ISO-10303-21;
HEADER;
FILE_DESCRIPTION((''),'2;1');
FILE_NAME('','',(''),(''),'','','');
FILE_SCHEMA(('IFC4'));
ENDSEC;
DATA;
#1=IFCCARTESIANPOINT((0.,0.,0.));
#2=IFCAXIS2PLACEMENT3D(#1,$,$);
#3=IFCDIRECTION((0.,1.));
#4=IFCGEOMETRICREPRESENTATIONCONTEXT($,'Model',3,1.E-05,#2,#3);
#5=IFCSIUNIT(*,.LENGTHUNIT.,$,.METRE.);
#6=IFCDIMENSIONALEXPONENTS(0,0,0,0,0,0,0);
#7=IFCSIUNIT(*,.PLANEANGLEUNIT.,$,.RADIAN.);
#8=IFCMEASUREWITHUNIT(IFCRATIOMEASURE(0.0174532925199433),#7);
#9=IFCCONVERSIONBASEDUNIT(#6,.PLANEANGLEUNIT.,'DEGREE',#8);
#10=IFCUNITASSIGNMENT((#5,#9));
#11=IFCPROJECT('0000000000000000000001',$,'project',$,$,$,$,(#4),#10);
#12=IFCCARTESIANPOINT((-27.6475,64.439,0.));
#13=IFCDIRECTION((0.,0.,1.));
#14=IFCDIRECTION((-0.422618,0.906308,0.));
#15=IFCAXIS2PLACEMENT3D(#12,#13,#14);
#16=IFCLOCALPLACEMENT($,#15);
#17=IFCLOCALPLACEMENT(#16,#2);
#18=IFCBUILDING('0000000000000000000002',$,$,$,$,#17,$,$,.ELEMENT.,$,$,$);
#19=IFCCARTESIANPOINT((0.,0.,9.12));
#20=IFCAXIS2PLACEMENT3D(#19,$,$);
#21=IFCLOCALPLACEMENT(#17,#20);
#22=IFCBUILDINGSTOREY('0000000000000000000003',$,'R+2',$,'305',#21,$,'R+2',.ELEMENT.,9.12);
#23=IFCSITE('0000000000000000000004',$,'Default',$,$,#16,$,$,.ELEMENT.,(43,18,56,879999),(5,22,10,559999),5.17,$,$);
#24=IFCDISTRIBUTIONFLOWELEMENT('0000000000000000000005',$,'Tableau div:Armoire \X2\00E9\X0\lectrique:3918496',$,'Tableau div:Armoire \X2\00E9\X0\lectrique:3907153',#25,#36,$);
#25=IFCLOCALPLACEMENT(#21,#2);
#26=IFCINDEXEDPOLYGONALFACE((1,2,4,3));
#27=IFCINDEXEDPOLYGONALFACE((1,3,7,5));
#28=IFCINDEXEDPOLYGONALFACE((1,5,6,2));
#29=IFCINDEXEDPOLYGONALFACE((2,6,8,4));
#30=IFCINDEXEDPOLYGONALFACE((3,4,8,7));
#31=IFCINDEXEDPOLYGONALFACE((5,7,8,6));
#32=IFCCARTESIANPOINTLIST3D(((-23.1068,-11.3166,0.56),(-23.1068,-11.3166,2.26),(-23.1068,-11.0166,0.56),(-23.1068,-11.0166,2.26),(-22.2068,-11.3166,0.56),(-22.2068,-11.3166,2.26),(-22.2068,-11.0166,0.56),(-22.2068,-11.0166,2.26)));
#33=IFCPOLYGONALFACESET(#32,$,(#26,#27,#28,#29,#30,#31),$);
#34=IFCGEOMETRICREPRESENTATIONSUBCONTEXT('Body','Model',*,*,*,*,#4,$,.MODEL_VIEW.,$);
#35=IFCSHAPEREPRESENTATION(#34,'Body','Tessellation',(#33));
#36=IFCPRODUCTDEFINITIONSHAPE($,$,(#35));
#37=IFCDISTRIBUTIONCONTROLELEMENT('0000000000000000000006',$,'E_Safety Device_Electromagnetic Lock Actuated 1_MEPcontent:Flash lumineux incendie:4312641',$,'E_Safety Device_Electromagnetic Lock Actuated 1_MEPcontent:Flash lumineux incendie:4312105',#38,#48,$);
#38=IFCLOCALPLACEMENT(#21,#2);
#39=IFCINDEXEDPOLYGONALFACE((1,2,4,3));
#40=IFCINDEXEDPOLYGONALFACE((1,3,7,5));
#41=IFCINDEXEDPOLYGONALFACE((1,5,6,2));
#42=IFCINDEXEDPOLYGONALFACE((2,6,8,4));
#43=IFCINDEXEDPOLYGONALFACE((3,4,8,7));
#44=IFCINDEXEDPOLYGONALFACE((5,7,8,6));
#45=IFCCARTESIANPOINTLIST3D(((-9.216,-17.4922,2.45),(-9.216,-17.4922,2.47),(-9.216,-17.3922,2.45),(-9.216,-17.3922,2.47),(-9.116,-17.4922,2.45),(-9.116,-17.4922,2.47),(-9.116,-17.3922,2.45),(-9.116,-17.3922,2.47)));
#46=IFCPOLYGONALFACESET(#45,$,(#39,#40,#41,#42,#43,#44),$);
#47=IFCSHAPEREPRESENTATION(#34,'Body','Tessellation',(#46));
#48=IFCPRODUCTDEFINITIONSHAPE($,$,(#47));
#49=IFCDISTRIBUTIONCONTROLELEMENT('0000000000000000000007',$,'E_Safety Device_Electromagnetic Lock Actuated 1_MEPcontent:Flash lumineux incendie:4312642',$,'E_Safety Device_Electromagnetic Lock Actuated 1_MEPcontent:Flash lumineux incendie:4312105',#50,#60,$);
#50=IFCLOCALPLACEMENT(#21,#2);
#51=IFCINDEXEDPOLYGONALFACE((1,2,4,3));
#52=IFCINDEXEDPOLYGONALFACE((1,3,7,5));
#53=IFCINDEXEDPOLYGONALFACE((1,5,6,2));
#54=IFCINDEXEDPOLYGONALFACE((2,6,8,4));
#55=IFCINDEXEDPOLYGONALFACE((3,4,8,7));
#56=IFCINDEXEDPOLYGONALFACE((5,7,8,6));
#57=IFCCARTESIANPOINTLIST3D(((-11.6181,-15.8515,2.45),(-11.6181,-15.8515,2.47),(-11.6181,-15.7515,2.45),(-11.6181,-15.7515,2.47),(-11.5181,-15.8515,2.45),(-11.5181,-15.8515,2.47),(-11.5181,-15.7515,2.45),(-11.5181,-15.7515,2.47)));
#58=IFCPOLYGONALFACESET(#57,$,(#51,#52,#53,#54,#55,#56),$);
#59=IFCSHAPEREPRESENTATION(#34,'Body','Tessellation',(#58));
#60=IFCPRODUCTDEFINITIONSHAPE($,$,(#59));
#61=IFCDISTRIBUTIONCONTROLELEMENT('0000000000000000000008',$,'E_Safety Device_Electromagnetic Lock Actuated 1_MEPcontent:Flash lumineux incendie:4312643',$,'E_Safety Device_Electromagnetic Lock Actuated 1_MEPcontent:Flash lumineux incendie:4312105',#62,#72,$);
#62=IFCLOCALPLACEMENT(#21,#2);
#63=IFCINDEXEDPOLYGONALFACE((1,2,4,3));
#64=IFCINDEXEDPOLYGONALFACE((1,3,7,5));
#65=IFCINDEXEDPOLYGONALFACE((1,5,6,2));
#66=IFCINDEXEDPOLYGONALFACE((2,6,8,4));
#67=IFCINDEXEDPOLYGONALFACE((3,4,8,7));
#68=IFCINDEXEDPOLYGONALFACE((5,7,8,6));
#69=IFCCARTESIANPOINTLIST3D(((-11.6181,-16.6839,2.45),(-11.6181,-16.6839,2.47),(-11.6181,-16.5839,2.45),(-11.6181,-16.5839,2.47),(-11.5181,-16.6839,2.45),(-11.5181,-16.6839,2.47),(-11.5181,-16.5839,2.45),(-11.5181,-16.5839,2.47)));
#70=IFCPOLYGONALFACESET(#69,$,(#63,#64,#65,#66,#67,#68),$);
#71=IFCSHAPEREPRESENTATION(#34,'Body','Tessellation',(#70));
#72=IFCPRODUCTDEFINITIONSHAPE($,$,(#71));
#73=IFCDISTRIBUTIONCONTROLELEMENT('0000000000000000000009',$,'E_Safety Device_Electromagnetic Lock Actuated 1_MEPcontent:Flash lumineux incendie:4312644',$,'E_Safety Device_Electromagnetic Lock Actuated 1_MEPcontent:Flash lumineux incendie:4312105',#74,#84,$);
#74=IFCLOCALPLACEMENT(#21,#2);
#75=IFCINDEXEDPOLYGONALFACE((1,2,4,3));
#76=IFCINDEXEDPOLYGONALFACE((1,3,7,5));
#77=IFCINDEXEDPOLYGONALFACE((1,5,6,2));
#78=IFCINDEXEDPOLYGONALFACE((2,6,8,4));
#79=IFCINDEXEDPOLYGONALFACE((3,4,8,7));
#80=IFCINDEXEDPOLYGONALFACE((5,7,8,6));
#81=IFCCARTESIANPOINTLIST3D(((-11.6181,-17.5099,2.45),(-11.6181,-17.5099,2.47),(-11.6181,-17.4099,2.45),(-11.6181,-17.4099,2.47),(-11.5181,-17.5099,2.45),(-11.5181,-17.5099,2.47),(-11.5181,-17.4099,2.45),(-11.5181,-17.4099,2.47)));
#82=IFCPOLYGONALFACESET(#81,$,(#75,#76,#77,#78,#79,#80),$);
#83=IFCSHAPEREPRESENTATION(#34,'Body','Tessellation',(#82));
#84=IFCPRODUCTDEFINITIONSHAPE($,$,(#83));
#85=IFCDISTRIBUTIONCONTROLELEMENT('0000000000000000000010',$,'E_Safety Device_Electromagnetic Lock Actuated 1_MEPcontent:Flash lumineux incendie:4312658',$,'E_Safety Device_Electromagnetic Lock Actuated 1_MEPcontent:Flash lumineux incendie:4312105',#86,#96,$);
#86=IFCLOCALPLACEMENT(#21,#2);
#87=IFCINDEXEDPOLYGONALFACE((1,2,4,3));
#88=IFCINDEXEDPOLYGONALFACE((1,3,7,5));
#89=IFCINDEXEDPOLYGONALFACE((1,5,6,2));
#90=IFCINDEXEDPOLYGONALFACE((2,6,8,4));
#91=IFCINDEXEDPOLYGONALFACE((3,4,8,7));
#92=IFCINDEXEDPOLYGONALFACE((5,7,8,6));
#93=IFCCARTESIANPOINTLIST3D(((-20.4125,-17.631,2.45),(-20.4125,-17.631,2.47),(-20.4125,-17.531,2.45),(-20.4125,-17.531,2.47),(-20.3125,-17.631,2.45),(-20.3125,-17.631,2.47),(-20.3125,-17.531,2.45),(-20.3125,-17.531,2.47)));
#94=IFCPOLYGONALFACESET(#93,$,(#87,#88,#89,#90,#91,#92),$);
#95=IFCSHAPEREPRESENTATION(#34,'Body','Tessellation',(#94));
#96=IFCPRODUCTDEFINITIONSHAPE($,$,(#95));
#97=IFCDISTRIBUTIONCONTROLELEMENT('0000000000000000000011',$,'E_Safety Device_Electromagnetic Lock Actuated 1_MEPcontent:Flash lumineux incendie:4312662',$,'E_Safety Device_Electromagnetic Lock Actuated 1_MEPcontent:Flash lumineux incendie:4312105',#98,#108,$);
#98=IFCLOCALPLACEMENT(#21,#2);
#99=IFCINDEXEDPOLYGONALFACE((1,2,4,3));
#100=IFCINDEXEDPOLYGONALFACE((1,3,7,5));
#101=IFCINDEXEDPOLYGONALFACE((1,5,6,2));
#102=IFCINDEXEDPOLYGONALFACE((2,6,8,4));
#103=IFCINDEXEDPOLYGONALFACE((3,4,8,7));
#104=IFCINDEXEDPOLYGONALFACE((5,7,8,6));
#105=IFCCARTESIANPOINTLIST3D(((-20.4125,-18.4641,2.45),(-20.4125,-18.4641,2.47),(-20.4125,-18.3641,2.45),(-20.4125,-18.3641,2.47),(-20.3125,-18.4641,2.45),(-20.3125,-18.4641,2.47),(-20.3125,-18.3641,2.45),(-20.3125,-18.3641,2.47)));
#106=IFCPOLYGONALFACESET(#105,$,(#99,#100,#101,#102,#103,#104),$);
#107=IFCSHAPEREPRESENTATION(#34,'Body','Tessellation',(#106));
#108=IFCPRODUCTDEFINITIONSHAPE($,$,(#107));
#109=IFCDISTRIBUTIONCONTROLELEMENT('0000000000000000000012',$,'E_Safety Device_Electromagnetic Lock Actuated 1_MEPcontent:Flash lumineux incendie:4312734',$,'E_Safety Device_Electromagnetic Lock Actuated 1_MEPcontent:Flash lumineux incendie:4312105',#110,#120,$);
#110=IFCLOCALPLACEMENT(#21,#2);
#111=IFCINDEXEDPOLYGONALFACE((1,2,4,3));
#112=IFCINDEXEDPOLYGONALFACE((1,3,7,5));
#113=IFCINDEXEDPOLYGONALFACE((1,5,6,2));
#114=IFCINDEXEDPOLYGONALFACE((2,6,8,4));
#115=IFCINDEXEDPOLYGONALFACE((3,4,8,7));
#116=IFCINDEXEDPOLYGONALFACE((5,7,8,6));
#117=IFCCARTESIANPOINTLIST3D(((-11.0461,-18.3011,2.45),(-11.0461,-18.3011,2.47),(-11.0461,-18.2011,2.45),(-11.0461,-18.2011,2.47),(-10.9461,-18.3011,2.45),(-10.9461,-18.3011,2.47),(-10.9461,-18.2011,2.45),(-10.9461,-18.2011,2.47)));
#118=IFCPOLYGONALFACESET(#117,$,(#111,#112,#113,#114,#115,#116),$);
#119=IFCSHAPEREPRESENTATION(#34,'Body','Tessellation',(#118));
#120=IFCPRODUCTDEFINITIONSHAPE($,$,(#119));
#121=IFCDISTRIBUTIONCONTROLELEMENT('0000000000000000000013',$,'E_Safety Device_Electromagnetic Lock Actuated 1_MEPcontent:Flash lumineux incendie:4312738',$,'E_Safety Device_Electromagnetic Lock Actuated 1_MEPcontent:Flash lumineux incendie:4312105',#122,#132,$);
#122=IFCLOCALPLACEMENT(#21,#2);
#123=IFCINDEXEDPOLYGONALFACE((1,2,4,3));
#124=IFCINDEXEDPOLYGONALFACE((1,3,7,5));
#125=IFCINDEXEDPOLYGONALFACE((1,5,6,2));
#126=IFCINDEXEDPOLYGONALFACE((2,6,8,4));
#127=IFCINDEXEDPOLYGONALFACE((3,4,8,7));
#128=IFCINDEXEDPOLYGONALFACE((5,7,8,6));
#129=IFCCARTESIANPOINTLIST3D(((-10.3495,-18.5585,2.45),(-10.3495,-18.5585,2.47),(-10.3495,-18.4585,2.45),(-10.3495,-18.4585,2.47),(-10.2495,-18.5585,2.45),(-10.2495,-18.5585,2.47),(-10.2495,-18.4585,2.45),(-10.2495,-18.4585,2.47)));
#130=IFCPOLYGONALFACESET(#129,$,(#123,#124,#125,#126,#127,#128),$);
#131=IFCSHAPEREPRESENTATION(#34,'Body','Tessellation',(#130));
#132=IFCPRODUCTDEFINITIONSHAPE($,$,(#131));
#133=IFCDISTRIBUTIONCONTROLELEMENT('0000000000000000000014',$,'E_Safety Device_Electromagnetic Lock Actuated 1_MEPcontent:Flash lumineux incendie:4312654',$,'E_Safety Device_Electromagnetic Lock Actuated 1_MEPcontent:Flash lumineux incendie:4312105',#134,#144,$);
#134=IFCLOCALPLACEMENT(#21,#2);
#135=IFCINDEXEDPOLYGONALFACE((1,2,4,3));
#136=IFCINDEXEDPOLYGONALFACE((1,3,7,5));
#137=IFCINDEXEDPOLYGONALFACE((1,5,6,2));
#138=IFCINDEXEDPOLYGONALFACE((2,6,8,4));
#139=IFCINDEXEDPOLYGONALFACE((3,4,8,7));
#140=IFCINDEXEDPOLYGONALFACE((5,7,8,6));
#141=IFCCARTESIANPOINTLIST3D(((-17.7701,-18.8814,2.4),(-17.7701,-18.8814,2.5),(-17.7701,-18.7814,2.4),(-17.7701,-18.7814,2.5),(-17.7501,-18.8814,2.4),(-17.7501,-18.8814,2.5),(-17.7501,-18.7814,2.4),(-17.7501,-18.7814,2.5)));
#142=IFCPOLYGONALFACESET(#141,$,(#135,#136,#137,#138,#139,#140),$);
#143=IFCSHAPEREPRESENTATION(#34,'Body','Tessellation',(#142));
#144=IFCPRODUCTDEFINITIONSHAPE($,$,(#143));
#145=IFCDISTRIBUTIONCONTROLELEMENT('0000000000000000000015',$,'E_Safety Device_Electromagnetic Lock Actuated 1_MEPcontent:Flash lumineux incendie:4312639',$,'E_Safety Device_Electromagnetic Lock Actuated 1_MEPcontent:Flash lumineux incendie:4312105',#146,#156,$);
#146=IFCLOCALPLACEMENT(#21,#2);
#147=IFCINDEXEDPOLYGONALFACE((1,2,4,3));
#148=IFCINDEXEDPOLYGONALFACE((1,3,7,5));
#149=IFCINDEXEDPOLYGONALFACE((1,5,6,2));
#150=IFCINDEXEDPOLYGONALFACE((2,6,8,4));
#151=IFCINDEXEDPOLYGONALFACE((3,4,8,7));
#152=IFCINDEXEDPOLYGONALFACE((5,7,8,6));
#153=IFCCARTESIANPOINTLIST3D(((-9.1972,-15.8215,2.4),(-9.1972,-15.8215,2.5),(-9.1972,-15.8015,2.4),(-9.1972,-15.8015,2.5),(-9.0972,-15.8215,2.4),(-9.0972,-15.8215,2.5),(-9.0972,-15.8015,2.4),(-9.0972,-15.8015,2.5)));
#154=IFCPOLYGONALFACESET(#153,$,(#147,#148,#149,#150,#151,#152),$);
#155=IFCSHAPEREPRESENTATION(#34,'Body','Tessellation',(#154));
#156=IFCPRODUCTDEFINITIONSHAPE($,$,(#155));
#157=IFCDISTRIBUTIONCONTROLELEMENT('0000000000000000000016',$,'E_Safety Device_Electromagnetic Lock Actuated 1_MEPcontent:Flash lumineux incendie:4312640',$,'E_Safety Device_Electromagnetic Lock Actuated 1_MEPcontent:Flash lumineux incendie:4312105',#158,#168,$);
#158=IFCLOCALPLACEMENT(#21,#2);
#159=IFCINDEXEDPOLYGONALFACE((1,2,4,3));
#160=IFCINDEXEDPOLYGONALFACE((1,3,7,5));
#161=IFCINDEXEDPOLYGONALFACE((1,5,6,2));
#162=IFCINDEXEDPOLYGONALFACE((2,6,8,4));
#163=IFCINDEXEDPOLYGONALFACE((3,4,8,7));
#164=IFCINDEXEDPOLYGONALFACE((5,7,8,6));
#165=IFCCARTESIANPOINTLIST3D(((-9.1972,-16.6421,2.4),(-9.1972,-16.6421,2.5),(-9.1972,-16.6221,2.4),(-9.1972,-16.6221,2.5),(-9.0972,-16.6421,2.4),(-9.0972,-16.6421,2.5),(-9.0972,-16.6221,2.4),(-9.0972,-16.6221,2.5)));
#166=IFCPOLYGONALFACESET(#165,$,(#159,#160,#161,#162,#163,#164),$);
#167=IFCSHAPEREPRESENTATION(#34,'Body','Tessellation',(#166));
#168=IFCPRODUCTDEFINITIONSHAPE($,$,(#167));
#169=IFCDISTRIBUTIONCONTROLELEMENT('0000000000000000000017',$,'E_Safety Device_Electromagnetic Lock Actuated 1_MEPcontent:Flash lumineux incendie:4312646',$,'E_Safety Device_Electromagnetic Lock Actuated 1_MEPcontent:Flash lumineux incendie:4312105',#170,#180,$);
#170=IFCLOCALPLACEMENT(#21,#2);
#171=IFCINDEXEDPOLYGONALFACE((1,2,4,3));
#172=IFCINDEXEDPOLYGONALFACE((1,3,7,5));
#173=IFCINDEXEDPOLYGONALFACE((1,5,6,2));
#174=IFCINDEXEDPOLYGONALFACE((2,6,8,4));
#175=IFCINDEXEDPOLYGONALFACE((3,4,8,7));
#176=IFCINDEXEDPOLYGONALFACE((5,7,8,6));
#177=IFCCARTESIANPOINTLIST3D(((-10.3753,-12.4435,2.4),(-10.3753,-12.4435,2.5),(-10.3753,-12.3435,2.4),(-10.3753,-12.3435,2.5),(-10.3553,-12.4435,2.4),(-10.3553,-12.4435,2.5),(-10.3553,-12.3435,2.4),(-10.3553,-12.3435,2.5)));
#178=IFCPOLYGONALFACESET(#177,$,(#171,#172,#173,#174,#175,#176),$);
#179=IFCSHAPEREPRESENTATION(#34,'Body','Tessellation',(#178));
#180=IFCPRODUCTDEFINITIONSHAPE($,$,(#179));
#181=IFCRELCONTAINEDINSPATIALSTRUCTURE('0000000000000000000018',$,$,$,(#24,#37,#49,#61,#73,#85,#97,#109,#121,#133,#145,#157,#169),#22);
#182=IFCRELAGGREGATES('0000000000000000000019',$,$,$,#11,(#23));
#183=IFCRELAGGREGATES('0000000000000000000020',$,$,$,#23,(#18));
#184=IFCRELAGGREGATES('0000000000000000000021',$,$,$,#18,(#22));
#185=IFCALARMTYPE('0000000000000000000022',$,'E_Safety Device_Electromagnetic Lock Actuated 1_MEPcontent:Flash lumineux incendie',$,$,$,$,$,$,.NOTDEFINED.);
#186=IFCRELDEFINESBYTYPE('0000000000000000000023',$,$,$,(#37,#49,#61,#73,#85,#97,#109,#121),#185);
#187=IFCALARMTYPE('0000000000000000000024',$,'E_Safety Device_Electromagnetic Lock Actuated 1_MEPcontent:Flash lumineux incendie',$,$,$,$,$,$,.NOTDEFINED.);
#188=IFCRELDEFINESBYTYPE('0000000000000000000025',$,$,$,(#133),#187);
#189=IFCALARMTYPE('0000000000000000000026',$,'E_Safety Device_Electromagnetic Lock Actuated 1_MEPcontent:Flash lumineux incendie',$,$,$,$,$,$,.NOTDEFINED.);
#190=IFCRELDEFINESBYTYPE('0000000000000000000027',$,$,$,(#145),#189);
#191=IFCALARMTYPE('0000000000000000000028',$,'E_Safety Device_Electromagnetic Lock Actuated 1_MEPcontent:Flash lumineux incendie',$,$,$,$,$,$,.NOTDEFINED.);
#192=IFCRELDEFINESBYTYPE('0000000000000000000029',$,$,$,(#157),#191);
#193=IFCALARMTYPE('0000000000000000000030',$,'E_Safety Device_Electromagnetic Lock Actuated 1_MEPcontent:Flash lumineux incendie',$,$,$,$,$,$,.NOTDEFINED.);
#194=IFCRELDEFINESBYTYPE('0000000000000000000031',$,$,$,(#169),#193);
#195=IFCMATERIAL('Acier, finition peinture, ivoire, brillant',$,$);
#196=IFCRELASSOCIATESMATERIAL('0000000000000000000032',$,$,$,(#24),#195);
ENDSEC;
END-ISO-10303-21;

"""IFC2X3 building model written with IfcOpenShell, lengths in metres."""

from ifc_helpers import new_model, entity, si_unit, converted_unit, direction, frame, frame_2d, origin, origin_2d_with_axis, place, context, subcontext, project, spatial, rectangle, extrude, source, transform, mapped, material, type_object, type_shapes, element, save


model = new_model("IFC2X3")

# Units and contexts
model_context = context("Model", 3, precision=1e-05, world=origin(), true_north=direction((0.0, 1.0)))
body_context = subcontext(model_context, "Body", "Model", "MODEL_VIEW")
ifc_project = project(units=[si_unit("LENGTHUNIT", "METRE"), converted_unit("PLANEANGLEUNIT", "DEGREE", entity("IfcRatioMeasure", 0.0174532925199433), si_unit("PLANEANGLEUNIT", "RADIAN"), dimensions=[0, 0, 0, 0, 0, 0, 0])], contexts=[model_context])

# Site, building, storey
site_placement = place(None, frame((-27.6475, 64.439, 0.0), z_axis=(0.0, 0.0, 1.0), x_axis=(-0.422618, 0.906308, 0.0)))
site = spatial("IfcSite", under=ifc_project, at=site_placement, Name="Default", CompositionType="ELEMENT", RefLatitude=(43, 18, 56, 879999), RefLongitude=(5, 22, 10, 559999), RefElevation=5.17)
building_placement = place(site_placement, origin())
building = spatial("IfcBuilding", under=site, at=building_placement, CompositionType="ELEMENT")
storey_placement = place(building_placement, frame((0.0, 0.0, 9.12)))
storey = spatial("IfcBuildingStorey", under=building, at=storey_placement, Name="R+2", ObjectType="305", LongName="R+2", CompositionType="ELEMENT", Elevation=9.12)

# Distribution flow element
ifc_material_1 = material(Name="Acier, finition peinture, ivoire, brillant")
shared_shape_1 = source(origin(), body_context, "Body", "SweptSolid", [
    extrude(rectangle(XDim=0.9, YDim=0.3, at=origin_2d_with_axis()), frame((0.0, -0.45, 0.0), z_axis=(0.0, 0.0, 1.0), x_axis=(0.0, 1.0, 0.0)), (0.0, 0.0, 1.0), 1.7),
])
distribution_flow_element_placement = place(storey_placement, frame((-22.2068, -11.1666, 0.56), z_axis=(0.0, 0.0, 1.0), x_axis=(0.0, -1.0, 0.0)))
element("IfcDistributionFlowElement", 1, at=distribution_flow_element_placement, inside=storey, material=ifc_material_1, Name="Tableau div:Armoire électrique:3918496", ObjectType="Tableau div:Armoire électrique:3907153", context=body_context, shape_type="MappedRepresentation", body=[
    mapped(shared_shape_1, transform((0.0, 0.0, 0.0), scale=1.0)),
])

# Distribution control elements
alarm_type_1 = type_object("IfcAlarmType", Name="E_Safety Device_Electromagnetic Lock Actuated 1_MEPcontent:Flash lumineux incendie", PredefinedType="NOTDEFINED")
shared_shape_2 = source(origin(), body_context, "Body", "SweptSolid", [
    extrude(rectangle(XDim=0.1, YDim=0.1, at=origin_2d_with_axis()), frame((0.0, 0.0, 0.0), z_axis=(0.0, 0.0, 1.0), x_axis=(0.0, -1.0, 0.0)), (0.0, 0.0, 1.0), 0.02),
])
type_shapes(alarm_type_1, [shared_shape_2])
for number, where, z_axis, x_axis, name in (
    (2, (-9.166, -17.4422, 2.45), (0.0, 0.0, 1.0), (0.0, -1.0, 0.0), "E_Safety Device_Electromagnetic Lock Actuated 1_MEPcontent:Flash lumineux incendie:4312641"),
    (3, (-11.5681, -15.8015, 2.45), (0.0, 0.0, 1.0), (0.0, -1.0, 0.0), "E_Safety Device_Electromagnetic Lock Actuated 1_MEPcontent:Flash lumineux incendie:4312642"),
    (4, (-11.5681, -16.6339, 2.45), (0.0, 0.0, 1.0), (0.0, -1.0, 0.0), "E_Safety Device_Electromagnetic Lock Actuated 1_MEPcontent:Flash lumineux incendie:4312643"),
    (5, (-11.5681, -17.4599, 2.45), (0.0, 0.0, 1.0), (0.0, -1.0, 0.0), "E_Safety Device_Electromagnetic Lock Actuated 1_MEPcontent:Flash lumineux incendie:4312644"),
    (6, (-20.3625, -17.581, 2.45), (0.0, 0.0, 1.0), (0.0, -1.0, 0.0), "E_Safety Device_Electromagnetic Lock Actuated 1_MEPcontent:Flash lumineux incendie:4312658"),
    (7, (-20.3625, -18.4141, 2.45), (0.0, 0.0, 1.0), (0.0, -1.0, 0.0), "E_Safety Device_Electromagnetic Lock Actuated 1_MEPcontent:Flash lumineux incendie:4312662"),
    (8, (-10.9961, -18.2511, 2.45), (0.0, 0.0, 1.0), (0.0, -1.0, 0.0), "E_Safety Device_Electromagnetic Lock Actuated 1_MEPcontent:Flash lumineux incendie:4312734"),
    (9, (-10.2995, -18.5085, 2.45), (0.0, 0.0, 1.0), (0.0, -1.0, 0.0), "E_Safety Device_Electromagnetic Lock Actuated 1_MEPcontent:Flash lumineux incendie:4312738"),
):
    element("IfcDistributionControlElement", number, at=place(storey_placement, frame(where, z_axis=z_axis, x_axis=x_axis)), inside=storey, type_object=alarm_type_1, Name=name, ObjectType="E_Safety Device_Electromagnetic Lock Actuated 1_MEPcontent:Flash lumineux incendie:4312105", context=body_context, shape_type="MappedRepresentation", body=[
        mapped(shared_shape_2, transform((0.0, 0.0, 0.0), scale=1.0)),
    ])
alarm_type_2 = type_object("IfcAlarmType", Name="E_Safety Device_Electromagnetic Lock Actuated 1_MEPcontent:Flash lumineux incendie", PredefinedType="NOTDEFINED")
shared_shape_3 = source(origin(), body_context, "Body", "SweptSolid", [
    extrude(rectangle(XDim=0.02, YDim=0.1, at=origin_2d_with_axis()), frame((0.0, -0.01, -0.05), z_axis=(0.0, 0.0, 1.0), x_axis=(0.0, 1.0, 0.0)), (0.0, 0.0, 1.0), 0.1),
])
type_shapes(alarm_type_2, [shared_shape_3])
distribution_control_element_1_placement = place(storey_placement, frame((-17.7501, -18.8314, 2.45), z_axis=(0.0, 0.0, 1.0), x_axis=(0.0, -1.0, 0.0)))
element("IfcDistributionControlElement", 10, at=distribution_control_element_1_placement, inside=storey, type_object=alarm_type_2, Name="E_Safety Device_Electromagnetic Lock Actuated 1_MEPcontent:Flash lumineux incendie:4312654", ObjectType="E_Safety Device_Electromagnetic Lock Actuated 1_MEPcontent:Flash lumineux incendie:4312105", context=body_context, shape_type="MappedRepresentation", body=[
    mapped(shared_shape_3, transform((0.0, 0.0, 0.0), scale=1.0)),
])
alarm_type_3 = type_object("IfcAlarmType", Name="E_Safety Device_Electromagnetic Lock Actuated 1_MEPcontent:Flash lumineux incendie", PredefinedType="NOTDEFINED")
shared_shape_4 = source(origin(), body_context, "Body", "SweptSolid", [
    extrude(rectangle(XDim=0.02, YDim=0.1, at=frame_2d((0.0, 0.0), x_axis=(1.0, 0.0))), frame((0.01, 0.0, -0.05), z_axis=(0.0, 0.0, 1.0), x_axis=(-1.0, 0.0, 0.0)), (0.0, 0.0, 1.0), 0.1),
])
type_shapes(alarm_type_3, [shared_shape_4])
distribution_control_element_2_placement = place(storey_placement, frame((-9.1472, -15.8015, 2.45), z_axis=(0.0, 0.0, 1.0), x_axis=(0.0, -1.0, 0.0)))
element("IfcDistributionControlElement", 11, at=distribution_control_element_2_placement, inside=storey, type_object=alarm_type_3, Name="E_Safety Device_Electromagnetic Lock Actuated 1_MEPcontent:Flash lumineux incendie:4312639", ObjectType="E_Safety Device_Electromagnetic Lock Actuated 1_MEPcontent:Flash lumineux incendie:4312105", context=body_context, shape_type="MappedRepresentation", body=[
    mapped(shared_shape_4, transform((0.0, 0.0, 0.0), scale=1.0)),
])
alarm_type_4 = type_object("IfcAlarmType", Name="E_Safety Device_Electromagnetic Lock Actuated 1_MEPcontent:Flash lumineux incendie", PredefinedType="NOTDEFINED")
shared_shape_5 = source(origin(), body_context, "Body", "SweptSolid", [
    extrude(rectangle(XDim=0.02, YDim=0.1, at=frame_2d((0.0, 0.0), x_axis=(1.0, 0.0))), frame((0.01, 0.0, -0.05), z_axis=(0.0, 0.0, 1.0), x_axis=(-1.0, 0.0, 0.0)), (0.0, 0.0, 1.0), 0.1),
])
type_shapes(alarm_type_4, [shared_shape_5])
distribution_control_element_3_placement = place(storey_placement, frame((-9.1472, -16.6221, 2.45), z_axis=(0.0, 0.0, 1.0), x_axis=(0.0, -1.0, 0.0)))
element("IfcDistributionControlElement", 12, at=distribution_control_element_3_placement, inside=storey, type_object=alarm_type_4, Name="E_Safety Device_Electromagnetic Lock Actuated 1_MEPcontent:Flash lumineux incendie:4312640", ObjectType="E_Safety Device_Electromagnetic Lock Actuated 1_MEPcontent:Flash lumineux incendie:4312105", context=body_context, shape_type="MappedRepresentation", body=[
    mapped(shared_shape_5, transform((0.0, 0.0, 0.0), scale=1.0)),
])
alarm_type_5 = type_object("IfcAlarmType", Name="E_Safety Device_Electromagnetic Lock Actuated 1_MEPcontent:Flash lumineux incendie", PredefinedType="NOTDEFINED")
shared_shape_6 = source(origin(), body_context, "Body", "SweptSolid", [
    extrude(rectangle(XDim=0.02, YDim=0.1, at=frame_2d((0.0, 0.0), x_axis=(1.0, 0.0))), frame((0.0, 0.01, -0.05), z_axis=(0.0, 0.0, 1.0), x_axis=(0.0, -1.0, 0.0)), (0.0, 0.0, 1.0), 0.1),
])
type_shapes(alarm_type_5, [shared_shape_6])
distribution_control_element_4_placement = place(storey_placement, frame((-10.3753, -12.3935, 2.45), z_axis=(0.0, 0.0, 1.0), x_axis=(0.0, -1.0, 0.0)))
element("IfcDistributionControlElement", 13, at=distribution_control_element_4_placement, inside=storey, type_object=alarm_type_5, Name="E_Safety Device_Electromagnetic Lock Actuated 1_MEPcontent:Flash lumineux incendie:4312646", ObjectType="E_Safety Device_Electromagnetic Lock Actuated 1_MEPcontent:Flash lumineux incendie:4312105", context=body_context, shape_type="MappedRepresentation", body=[
    mapped(shared_shape_6, transform((0.0, 0.0, 0.0), scale=1.0)),
])

save(model, "model.ifc")
